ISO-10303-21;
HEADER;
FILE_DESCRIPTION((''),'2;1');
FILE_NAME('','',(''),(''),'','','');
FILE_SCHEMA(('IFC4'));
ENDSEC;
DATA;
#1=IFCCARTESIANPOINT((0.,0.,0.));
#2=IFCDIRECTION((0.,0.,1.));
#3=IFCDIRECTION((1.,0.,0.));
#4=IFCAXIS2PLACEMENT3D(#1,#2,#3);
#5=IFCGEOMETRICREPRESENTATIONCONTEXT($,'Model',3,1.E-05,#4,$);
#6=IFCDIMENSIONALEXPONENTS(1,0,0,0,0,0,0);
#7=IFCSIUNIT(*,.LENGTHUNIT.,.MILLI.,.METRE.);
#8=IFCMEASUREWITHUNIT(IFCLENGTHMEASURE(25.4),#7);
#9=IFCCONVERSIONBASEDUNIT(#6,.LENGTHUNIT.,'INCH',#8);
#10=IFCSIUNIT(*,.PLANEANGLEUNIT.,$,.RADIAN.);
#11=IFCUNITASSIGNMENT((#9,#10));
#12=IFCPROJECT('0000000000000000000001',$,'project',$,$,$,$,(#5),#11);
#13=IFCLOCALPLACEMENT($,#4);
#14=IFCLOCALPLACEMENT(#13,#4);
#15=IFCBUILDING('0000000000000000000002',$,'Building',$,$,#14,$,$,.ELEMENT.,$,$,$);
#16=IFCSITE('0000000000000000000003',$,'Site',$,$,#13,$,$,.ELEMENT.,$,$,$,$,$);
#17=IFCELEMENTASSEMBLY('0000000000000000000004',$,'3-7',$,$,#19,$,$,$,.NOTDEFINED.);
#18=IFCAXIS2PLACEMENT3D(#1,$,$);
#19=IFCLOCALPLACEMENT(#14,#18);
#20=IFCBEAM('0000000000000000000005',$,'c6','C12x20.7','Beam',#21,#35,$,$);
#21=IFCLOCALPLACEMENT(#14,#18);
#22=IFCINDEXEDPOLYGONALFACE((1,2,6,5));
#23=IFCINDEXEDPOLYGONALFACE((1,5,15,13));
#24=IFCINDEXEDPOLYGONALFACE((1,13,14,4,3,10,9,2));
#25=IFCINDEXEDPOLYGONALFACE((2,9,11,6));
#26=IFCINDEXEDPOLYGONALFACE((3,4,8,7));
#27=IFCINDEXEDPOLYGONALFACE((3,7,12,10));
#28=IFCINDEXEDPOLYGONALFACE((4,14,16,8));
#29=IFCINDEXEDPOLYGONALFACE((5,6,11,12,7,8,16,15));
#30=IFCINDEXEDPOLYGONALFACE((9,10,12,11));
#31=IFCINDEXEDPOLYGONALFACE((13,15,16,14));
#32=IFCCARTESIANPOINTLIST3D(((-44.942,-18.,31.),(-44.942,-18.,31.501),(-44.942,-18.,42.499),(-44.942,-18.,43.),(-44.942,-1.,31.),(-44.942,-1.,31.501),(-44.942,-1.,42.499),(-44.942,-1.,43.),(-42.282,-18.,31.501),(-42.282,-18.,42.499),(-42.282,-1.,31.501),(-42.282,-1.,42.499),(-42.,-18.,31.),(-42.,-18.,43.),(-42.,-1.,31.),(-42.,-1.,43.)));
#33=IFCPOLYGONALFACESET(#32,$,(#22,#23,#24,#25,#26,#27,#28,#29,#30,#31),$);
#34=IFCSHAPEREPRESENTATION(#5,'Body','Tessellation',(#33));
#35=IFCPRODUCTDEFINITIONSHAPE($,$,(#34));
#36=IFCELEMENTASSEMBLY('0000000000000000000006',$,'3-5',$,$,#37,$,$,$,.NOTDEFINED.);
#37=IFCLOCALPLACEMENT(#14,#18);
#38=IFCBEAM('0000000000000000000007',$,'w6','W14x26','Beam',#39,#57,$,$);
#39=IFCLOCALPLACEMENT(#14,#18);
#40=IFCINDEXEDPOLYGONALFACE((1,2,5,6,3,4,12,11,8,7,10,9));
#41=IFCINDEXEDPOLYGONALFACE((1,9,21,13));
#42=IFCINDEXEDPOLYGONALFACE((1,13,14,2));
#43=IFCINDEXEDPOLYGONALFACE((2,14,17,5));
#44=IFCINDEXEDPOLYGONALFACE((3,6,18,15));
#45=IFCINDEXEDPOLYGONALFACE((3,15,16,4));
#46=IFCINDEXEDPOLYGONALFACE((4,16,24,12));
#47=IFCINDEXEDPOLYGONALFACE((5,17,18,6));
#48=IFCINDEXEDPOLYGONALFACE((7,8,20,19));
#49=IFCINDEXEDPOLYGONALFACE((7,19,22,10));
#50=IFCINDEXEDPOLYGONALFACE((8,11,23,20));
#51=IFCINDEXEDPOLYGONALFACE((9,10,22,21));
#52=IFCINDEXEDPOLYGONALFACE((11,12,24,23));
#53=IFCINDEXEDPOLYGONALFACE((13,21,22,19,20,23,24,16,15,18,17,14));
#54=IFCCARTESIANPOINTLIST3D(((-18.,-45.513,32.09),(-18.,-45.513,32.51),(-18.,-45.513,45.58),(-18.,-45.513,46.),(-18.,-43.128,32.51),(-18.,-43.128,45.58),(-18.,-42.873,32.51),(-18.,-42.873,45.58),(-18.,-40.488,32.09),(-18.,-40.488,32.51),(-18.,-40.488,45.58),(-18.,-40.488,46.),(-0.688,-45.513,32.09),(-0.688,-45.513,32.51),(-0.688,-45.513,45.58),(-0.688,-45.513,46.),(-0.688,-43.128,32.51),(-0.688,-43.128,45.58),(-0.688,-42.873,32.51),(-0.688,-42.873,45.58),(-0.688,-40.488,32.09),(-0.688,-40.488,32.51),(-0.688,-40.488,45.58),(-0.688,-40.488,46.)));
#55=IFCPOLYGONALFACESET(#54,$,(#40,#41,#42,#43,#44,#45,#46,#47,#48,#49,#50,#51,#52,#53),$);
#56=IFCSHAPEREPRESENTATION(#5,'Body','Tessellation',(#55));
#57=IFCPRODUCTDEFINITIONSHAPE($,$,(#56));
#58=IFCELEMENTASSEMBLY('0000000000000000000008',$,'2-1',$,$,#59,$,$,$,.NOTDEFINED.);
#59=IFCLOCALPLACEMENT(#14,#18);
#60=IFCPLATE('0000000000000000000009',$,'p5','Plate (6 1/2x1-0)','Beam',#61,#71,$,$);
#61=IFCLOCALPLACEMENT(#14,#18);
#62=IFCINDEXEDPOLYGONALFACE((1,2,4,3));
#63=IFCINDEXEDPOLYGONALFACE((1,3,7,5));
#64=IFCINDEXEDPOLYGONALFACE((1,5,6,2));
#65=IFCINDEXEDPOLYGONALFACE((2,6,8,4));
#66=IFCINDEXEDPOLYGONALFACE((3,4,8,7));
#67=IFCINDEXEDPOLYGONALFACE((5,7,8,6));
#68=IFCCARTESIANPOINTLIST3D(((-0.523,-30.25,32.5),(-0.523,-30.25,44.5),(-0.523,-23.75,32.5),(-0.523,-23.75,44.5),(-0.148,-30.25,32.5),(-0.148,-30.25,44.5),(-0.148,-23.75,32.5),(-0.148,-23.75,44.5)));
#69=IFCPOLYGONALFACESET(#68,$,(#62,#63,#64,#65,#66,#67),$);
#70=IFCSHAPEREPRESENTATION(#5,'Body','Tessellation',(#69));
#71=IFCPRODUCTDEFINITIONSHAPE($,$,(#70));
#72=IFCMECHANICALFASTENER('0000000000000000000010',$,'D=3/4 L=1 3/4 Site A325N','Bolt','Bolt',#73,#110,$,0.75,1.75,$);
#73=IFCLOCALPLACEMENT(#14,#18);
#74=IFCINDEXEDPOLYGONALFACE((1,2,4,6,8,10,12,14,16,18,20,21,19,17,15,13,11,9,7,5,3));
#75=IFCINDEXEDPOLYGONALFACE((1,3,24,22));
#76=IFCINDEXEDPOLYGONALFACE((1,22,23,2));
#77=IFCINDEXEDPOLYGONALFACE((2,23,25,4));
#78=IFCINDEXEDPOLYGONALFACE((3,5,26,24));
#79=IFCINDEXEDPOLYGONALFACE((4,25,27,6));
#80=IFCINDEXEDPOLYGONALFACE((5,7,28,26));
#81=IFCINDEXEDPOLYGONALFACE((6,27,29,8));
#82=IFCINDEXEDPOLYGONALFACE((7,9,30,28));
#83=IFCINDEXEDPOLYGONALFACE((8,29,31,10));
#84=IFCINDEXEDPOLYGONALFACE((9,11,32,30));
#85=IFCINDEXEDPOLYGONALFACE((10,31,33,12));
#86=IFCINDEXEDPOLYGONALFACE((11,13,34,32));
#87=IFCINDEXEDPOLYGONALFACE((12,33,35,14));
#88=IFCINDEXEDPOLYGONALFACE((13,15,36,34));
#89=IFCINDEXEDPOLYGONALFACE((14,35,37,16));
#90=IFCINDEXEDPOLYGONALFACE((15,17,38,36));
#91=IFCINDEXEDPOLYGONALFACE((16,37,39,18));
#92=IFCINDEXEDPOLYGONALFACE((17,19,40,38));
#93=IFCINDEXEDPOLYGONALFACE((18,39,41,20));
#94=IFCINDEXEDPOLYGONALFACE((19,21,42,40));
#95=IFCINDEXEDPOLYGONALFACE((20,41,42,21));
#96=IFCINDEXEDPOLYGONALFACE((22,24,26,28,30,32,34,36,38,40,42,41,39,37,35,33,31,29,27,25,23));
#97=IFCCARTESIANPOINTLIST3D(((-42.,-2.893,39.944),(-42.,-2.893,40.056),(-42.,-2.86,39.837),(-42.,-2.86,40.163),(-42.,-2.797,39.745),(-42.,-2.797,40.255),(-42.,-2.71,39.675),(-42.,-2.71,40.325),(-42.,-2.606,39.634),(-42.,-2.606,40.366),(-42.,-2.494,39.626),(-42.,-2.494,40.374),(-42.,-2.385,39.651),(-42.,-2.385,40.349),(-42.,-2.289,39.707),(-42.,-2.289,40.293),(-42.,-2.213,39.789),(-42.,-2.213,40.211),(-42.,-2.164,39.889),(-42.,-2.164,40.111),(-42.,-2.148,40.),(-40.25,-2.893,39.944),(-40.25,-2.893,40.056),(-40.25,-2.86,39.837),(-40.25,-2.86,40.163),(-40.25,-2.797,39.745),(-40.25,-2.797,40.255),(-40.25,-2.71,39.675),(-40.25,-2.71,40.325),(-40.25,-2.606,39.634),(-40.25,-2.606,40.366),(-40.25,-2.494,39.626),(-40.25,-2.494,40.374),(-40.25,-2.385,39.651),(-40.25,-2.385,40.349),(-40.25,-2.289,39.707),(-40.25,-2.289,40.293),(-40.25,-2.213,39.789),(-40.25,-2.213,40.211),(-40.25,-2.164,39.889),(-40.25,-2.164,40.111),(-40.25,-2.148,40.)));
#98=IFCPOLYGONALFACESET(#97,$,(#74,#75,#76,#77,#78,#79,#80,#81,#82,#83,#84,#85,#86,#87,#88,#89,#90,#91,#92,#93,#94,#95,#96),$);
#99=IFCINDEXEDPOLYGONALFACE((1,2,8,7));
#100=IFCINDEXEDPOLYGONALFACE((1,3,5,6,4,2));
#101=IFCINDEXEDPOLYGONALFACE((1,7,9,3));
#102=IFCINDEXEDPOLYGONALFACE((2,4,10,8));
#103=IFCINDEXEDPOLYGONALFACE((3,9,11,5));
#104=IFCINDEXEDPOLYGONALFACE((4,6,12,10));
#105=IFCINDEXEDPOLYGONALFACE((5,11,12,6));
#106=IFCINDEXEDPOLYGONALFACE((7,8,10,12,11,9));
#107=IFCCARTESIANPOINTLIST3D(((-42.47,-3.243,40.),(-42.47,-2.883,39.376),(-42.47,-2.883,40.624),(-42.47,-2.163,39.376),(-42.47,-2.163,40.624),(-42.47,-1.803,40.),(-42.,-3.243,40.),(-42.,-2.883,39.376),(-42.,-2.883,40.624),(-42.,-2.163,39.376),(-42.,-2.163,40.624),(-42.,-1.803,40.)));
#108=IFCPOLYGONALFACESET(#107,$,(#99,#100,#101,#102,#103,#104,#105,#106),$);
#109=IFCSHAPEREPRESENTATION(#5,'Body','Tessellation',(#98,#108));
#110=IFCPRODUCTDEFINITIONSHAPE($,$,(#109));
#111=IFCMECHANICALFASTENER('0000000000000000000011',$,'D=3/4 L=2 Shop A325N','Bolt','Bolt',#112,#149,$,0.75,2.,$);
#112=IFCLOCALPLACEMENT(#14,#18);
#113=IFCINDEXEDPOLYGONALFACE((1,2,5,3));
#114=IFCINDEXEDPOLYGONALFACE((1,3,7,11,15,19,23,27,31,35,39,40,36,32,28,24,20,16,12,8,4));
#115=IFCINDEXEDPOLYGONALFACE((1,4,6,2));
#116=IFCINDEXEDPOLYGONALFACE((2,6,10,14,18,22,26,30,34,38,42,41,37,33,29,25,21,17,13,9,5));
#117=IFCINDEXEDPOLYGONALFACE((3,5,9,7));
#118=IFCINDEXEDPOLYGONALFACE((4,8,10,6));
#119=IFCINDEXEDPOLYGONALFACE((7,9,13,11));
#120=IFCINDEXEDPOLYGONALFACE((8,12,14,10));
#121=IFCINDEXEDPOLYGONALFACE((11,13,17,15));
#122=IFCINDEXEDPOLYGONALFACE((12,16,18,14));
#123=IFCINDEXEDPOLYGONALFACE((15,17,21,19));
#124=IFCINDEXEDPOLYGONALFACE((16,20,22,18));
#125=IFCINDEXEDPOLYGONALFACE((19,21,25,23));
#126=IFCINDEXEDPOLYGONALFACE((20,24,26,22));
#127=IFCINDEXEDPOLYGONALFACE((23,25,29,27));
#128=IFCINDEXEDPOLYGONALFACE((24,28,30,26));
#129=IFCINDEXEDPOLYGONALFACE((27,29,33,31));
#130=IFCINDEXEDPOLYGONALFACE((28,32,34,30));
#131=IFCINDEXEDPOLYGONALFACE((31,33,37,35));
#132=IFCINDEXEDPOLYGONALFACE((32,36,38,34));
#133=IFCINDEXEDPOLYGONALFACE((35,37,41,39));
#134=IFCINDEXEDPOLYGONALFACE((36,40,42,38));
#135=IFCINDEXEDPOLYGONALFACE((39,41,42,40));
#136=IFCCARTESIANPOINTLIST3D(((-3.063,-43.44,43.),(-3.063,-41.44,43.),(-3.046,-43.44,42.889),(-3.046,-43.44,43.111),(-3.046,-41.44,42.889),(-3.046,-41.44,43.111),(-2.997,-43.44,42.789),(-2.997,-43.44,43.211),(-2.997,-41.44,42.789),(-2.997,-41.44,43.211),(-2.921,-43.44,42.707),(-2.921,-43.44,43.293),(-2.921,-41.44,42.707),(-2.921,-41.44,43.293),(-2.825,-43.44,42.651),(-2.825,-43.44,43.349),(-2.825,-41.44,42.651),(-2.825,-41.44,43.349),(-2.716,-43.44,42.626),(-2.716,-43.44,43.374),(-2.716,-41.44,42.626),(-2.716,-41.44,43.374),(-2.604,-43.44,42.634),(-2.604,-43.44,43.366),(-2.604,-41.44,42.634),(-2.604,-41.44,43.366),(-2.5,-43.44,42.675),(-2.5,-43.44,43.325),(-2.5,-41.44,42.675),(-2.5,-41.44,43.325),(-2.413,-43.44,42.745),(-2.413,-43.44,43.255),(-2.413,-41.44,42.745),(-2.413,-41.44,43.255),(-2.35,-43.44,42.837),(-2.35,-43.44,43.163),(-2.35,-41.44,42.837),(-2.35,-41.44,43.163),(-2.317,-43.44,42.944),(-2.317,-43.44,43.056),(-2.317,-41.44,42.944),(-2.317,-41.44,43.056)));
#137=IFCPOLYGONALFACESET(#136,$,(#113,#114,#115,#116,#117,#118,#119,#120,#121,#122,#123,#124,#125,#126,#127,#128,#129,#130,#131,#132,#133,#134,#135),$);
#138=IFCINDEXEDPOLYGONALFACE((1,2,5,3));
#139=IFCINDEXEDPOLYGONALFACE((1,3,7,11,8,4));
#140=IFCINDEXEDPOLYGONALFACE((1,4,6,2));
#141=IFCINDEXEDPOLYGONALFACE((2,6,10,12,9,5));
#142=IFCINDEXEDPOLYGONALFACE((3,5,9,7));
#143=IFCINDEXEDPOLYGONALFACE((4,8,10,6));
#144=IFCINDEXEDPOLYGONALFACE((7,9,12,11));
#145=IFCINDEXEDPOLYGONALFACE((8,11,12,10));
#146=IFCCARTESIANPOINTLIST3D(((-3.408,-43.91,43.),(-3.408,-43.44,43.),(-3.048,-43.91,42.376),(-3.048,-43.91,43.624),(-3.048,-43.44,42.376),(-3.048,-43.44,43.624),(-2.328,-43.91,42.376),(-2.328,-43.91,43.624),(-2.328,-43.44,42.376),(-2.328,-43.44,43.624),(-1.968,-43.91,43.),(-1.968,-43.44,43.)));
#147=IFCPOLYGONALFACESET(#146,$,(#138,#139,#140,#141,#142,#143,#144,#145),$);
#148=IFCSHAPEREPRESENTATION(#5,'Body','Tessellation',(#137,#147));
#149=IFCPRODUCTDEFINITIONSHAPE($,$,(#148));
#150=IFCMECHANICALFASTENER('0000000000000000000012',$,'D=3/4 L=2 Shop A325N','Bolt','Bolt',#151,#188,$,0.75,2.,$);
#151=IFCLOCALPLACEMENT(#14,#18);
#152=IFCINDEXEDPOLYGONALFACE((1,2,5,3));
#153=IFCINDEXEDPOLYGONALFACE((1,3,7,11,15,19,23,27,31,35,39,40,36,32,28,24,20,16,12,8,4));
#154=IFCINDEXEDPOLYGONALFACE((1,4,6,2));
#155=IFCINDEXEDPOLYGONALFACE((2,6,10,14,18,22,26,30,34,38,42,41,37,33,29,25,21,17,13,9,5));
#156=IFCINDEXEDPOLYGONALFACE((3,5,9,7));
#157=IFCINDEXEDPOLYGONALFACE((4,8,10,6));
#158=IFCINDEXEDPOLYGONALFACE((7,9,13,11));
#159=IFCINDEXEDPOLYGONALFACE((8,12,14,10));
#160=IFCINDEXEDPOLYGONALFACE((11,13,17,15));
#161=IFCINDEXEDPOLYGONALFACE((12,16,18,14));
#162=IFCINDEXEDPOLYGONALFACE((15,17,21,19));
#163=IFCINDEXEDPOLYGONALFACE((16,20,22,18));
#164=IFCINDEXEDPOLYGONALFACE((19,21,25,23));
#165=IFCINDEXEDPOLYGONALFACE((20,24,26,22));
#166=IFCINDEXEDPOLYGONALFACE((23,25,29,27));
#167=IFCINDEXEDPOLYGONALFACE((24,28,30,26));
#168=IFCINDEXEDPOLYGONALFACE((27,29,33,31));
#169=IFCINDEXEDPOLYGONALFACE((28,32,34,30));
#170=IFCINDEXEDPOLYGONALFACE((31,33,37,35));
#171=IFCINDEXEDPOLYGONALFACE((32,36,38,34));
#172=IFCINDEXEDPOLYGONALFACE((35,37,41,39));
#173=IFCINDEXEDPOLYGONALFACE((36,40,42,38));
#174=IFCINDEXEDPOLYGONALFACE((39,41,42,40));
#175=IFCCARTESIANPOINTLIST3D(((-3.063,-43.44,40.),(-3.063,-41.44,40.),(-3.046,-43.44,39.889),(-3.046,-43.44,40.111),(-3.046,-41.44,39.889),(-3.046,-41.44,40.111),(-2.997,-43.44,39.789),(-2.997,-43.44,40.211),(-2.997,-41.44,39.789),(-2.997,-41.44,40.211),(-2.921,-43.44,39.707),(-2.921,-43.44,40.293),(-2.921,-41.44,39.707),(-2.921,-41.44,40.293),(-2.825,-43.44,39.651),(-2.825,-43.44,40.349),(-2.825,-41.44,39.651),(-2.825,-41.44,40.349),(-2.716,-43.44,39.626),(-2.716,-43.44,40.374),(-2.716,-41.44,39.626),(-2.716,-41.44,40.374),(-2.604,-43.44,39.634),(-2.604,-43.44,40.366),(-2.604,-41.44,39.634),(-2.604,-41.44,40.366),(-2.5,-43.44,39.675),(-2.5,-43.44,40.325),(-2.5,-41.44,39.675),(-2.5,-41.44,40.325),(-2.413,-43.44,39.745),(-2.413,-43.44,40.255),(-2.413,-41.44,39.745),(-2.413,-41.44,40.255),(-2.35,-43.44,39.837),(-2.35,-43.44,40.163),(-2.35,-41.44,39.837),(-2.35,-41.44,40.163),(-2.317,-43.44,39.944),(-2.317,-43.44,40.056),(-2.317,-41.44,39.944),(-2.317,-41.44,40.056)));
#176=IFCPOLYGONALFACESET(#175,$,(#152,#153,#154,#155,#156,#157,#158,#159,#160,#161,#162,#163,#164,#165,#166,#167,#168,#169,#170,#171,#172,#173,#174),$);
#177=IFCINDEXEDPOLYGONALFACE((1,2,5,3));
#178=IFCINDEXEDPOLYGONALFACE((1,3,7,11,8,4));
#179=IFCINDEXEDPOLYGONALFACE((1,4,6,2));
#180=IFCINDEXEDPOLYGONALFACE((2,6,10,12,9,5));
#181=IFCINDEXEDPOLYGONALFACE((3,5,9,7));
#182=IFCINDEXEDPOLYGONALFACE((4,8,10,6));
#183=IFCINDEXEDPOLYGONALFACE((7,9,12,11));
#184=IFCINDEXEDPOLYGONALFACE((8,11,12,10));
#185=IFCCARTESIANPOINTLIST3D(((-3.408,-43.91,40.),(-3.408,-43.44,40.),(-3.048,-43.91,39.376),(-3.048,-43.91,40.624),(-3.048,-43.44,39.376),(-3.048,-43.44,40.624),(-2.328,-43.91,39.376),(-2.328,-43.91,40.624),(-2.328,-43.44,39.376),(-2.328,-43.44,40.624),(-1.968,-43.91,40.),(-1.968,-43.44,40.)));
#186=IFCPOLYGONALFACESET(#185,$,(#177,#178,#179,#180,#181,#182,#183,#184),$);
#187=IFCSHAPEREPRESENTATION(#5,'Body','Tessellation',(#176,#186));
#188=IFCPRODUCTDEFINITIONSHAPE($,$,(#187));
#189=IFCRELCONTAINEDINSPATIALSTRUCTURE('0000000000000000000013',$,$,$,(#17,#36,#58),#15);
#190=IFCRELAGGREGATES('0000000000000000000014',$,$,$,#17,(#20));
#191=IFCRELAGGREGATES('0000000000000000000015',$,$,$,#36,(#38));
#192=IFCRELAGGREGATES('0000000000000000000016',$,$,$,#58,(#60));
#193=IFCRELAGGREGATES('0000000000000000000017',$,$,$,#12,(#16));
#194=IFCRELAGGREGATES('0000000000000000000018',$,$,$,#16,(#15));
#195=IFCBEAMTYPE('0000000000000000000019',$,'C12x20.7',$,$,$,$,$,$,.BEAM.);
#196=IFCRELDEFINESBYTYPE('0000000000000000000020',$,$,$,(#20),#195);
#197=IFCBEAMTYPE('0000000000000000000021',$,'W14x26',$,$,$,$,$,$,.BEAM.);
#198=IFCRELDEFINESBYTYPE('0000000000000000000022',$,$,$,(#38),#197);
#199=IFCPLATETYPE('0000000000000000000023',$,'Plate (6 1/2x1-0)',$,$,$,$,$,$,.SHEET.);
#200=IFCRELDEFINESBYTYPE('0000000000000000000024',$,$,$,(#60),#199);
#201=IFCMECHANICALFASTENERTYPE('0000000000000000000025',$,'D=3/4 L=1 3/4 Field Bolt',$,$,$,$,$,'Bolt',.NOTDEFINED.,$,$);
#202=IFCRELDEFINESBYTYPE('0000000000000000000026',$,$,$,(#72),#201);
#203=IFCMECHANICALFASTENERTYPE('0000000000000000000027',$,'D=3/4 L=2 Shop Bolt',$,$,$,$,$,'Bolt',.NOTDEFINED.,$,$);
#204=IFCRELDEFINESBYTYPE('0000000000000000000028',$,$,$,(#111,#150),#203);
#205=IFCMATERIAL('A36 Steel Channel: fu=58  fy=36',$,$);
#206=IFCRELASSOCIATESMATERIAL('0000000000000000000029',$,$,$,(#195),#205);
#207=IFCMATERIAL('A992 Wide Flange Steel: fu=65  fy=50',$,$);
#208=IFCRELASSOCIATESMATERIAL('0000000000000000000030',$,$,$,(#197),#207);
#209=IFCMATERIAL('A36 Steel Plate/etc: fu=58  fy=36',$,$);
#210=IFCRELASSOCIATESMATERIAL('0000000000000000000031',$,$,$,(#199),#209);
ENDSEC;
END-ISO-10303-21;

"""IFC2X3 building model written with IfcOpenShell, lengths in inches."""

from ifc_helpers import new_model, entity, si_unit, converted_unit, frame, frame_2d, origin_with_axes, origin_2d_with_axis, place, context, project, spatial, polyline, circle, i_section, u_section, outline, transform_2d, derived_profile, extrude, source, transform, mapped, material, type_object, type_shapes, element, aggregate, save


model = new_model("IFC2X3")

# Units and contexts
model_context = context("Model", 3, precision=1e-05, world=origin_with_axes())
ifc_project = project(units=[converted_unit("LENGTHUNIT", "INCH", entity("IfcLengthMeasure", 25.4), si_unit("LENGTHUNIT", "METRE", prefix="MILLI"), dimensions=[1, 0, 0, 0, 0, 0, 0]), si_unit("PLANEANGLEUNIT", "RADIAN")], contexts=[model_context])

# Site, building
site_placement = place(None, origin_with_axes())
site = spatial("IfcSite", under=ifc_project, at=site_placement, Name="Site", CompositionType="ELEMENT")
building_placement = place(site_placement, origin_with_axes())
building = spatial("IfcBuilding", under=site, at=building_placement, Name="Building", CompositionType="ELEMENT")

# Element assemblies, beams
assembly_1_placement = place(building_placement, frame((-42.0, 0.0, 43.0), z_axis=(0.0, 0.0, 1.0), x_axis=(0.0, -1.0, 0.0)))
assembly_1 = element("IfcElementAssembly", 1, at=assembly_1_placement, inside=building, Name="3-7", PredefinedType="NOTDEFINED")
ifc_material_1 = material(Name="A36 Steel Channel: fu=58  fy=36")
beam_type_1 = type_object("IfcBeamType", Name="C12x20.7", PredefinedType="BEAM", material=ifc_material_1)
shared_shape_1 = source(origin_with_axes(), model_context, "Body", "SweptSolid", [
    extrude(derived_profile(u_section(Depth=12.0, FlangeWidth=2.942, WebThickness=0.282, FlangeThickness=0.501, at=frame_2d((1.471, -6.0), x_axis=(1.0, 0.0))), transform_2d((0.0, 0.0), x_axis=(-1.0, 0.0), y_axis=(0.0, 1.0))), frame((0.0, 0.0, 0.0), z_axis=(1.0, 0.0, 0.0), x_axis=(0.0, 1.0, 0.0)), (0.0, 0.0, 1.0), 17.0),
])
type_shapes(beam_type_1, [shared_shape_1])
beam_1_placement = place(assembly_1_placement, frame((18.0, 0.0, 0.0), z_axis=(0.0, 0.0, 1.0), x_axis=(-1.0, 0.0, 0.0)))
beam_1 = element("IfcBeam", 2, at=beam_1_placement, type_object=beam_type_1, Name="c6", Description="C12x20.7", ObjectType="Beam", context=model_context, shape_type="MappedRepresentation", body=[
    mapped(shared_shape_1, transform((0.0, 0.0, 0.0), scale=1.0)),
])
aggregate(assembly_1, [beam_1])
assembly_2_placement = place(building_placement, frame((0.0, -43.0, 46.0), z_axis=(0.0, 0.0, 1.0), x_axis=(-1.0, 0.0, 0.0)))
assembly_2 = element("IfcElementAssembly", 3, at=assembly_2_placement, inside=building, Name="3-5", PredefinedType="NOTDEFINED")
ifc_material_2 = material(Name="A992 Wide Flange Steel: fu=65  fy=50")
beam_type_2 = type_object("IfcBeamType", Name="W14x26", PredefinedType="BEAM", material=ifc_material_2)
shared_shape_2 = source(origin_with_axes(), model_context, "Body", "SweptSolid", [
    extrude(i_section(OverallWidth=5.025, OverallDepth=13.91, WebThickness=0.255, FlangeThickness=0.42, at=frame_2d((0.0, -6.955), x_axis=(1.0, 0.0))), frame((0.0, 0.0, 0.0), z_axis=(1.0, 0.0, 0.0), x_axis=(0.0, 1.0, 0.0)), (0.0, 0.0, 1.0), 17.312),
])
type_shapes(beam_type_2, [shared_shape_2])
beam_2_placement = place(assembly_2_placement, frame((0.688, 0.0, 0.0), z_axis=(0.0, 0.0, 1.0), x_axis=(1.0, 0.0, 0.0)))
beam_2 = element("IfcBeam", 4, at=beam_2_placement, type_object=beam_type_2, Name="w6", Description="W14x26", ObjectType="Beam", context=model_context, shape_type="MappedRepresentation", body=[
    mapped(shared_shape_2, transform((0.0, 0.0, 0.0), scale=1.0)),
])
aggregate(assembly_2, [beam_2])

# Element assembly, plate
assembly_3_placement = place(building_placement, frame((0.0, 0.0, 46.0), z_axis=(0.0, 0.0, 1.0), x_axis=(0.0, -1.0, 0.0)))
assembly_3 = element("IfcElementAssembly", 5, at=assembly_3_placement, inside=building, Name="2-1", PredefinedType="NOTDEFINED")
ifc_material_3 = material(Name="A36 Steel Plate/etc: fu=58  fy=36")
plate_type = type_object("IfcPlateType", Name="Plate (6 1/2x1-0)", PredefinedType="SHEET", material=ifc_material_3)
shared_shape_3 = source(origin_with_axes(), model_context, "Body", "SweptSolid", [
    extrude(outline(polyline([(0.0, -6.5), (-12.0, -6.5), (-12.0, 0.0), (0.0, 0.0), (0.0, -6.5)])), frame((-0.188, 0.0, 0.0), z_axis=(1.0, 0.0, 0.0), x_axis=(0.0, 1.0, 0.0)), (0.0, 0.0, 1.0), 0.375),
])
type_shapes(plate_type, [shared_shape_3])
plate_placement = place(assembly_3_placement, frame((30.25, -0.335, -1.5), z_axis=(1.0, 0.0, 0.0), x_axis=(0.0, 1.0, 0.0)))
plate = element("IfcPlate", 6, at=plate_placement, type_object=plate_type, Name="p5", Description="Plate (6 1/2x1-0)", ObjectType="Beam", context=model_context, shape_type="MappedRepresentation", body=[
    mapped(shared_shape_3, transform((0.0, 0.0, 0.0), scale=1.0)),
])
aggregate(assembly_3, [plate])

# Mechanical fasteners
mechanical_fastener_type_1 = type_object("IfcMechanicalFastenerType", Name="D=3/4 L=1 3/4 Field Bolt", ElementType="Bolt")
shared_shape_4 = source(origin_with_axes(), model_context, "Body", "SweptSolid", [
    extrude(circle(Radius=0.375, at=origin_2d_with_axis()), frame((0.0, 0.0, 0.0), z_axis=(1.0, 0.0, 0.0), x_axis=(0.0, 1.0, 0.0)), (0.0, 0.0, 1.0), 1.75),
    extrude(outline(polyline([(-0.72, 0.0), (-0.36, 0.624), (0.36, 0.624), (0.72, 0.0), (0.36, -0.624), (-0.36, -0.624), (-0.72, 0.0)])), frame((0.0, 0.0, 0.0), z_axis=(1.0, 0.0, 0.0), x_axis=(0.0, 1.0, 0.0)), (0.0, 0.0, -1.0), 0.47),
])
type_shapes(mechanical_fastener_type_1, [shared_shape_4])
placement_1 = place(assembly_1_placement, frame((2.523, 0.0, -9.0), z_axis=(0.0, 0.0, 1.0), x_axis=(0.0, 1.0, 0.0)))
mechanical_fastener_1_placement = place(placement_1, frame((0.0, 0.0, 6.0), z_axis=(0.0, 0.0, 1.0), x_axis=(1.0, 0.0, 0.0)))
element("IfcMechanicalFastener", 7, at=mechanical_fastener_1_placement, type_object=mechanical_fastener_type_1, Name="D=3/4 L=1 3/4 Site A325N", Description="Bolt", ObjectType="Bolt", NominalDiameter=0.75, NominalLength=1.75, context=model_context, shape_type="MappedRepresentation", body=[
    mapped(shared_shape_4, transform((0.0, 0.0, 0.0), scale=1.0)),
])
mechanical_fastener_type_2 = type_object("IfcMechanicalFastenerType", Name="D=3/4 L=2 Shop Bolt", ElementType="Bolt")
shared_shape_5 = source(origin_with_axes(), model_context, "Body", "SweptSolid", [
    extrude(circle(Radius=0.375, at=origin_2d_with_axis()), frame((0.0, 0.0, 0.0), z_axis=(1.0, 0.0, 0.0), x_axis=(0.0, 1.0, 0.0)), (0.0, 0.0, 1.0), 2.0),
    extrude(outline(polyline([(-0.72, 0.0), (-0.36, 0.624), (0.36, 0.624), (0.72, 0.0), (0.36, -0.624), (-0.36, -0.624), (-0.72, 0.0)])), frame((0.0, 0.0, 0.0), z_axis=(1.0, 0.0, 0.0), x_axis=(0.0, 1.0, 0.0)), (0.0, 0.0, -1.0), 0.47),
])
type_shapes(mechanical_fastener_type_2, [shared_shape_5])
placement_2 = place(assembly_2_placement, frame((2.688, 0.44, -9.0), z_axis=(0.0, 0.0, 1.0), x_axis=(0.0, -1.0, 0.0)))
for number, where, z_axis, x_axis, name in (
    (8, (0.0, 0.0, 6.0), (0.0, 0.0, 1.0), (1.0, 0.0, 0.0), "D=3/4 L=2 Shop A325N"),
    (9, (0.0, 0.0, 3.0), (0.0, 0.0, 1.0), (1.0, 0.0, 0.0), "D=3/4 L=2 Shop A325N"),
):
    element("IfcMechanicalFastener", number, at=place(placement_2, frame(where, z_axis=z_axis, x_axis=x_axis)), type_object=mechanical_fastener_type_2, Name=name, Description="Bolt", ObjectType="Bolt", NominalDiameter=0.75, NominalLength=2.0, context=model_context, shape_type="MappedRepresentation", body=[
        mapped(shared_shape_5, transform((0.0, 0.0, 0.0), scale=1.0)),
    ])

save(model, "model.ifc")
